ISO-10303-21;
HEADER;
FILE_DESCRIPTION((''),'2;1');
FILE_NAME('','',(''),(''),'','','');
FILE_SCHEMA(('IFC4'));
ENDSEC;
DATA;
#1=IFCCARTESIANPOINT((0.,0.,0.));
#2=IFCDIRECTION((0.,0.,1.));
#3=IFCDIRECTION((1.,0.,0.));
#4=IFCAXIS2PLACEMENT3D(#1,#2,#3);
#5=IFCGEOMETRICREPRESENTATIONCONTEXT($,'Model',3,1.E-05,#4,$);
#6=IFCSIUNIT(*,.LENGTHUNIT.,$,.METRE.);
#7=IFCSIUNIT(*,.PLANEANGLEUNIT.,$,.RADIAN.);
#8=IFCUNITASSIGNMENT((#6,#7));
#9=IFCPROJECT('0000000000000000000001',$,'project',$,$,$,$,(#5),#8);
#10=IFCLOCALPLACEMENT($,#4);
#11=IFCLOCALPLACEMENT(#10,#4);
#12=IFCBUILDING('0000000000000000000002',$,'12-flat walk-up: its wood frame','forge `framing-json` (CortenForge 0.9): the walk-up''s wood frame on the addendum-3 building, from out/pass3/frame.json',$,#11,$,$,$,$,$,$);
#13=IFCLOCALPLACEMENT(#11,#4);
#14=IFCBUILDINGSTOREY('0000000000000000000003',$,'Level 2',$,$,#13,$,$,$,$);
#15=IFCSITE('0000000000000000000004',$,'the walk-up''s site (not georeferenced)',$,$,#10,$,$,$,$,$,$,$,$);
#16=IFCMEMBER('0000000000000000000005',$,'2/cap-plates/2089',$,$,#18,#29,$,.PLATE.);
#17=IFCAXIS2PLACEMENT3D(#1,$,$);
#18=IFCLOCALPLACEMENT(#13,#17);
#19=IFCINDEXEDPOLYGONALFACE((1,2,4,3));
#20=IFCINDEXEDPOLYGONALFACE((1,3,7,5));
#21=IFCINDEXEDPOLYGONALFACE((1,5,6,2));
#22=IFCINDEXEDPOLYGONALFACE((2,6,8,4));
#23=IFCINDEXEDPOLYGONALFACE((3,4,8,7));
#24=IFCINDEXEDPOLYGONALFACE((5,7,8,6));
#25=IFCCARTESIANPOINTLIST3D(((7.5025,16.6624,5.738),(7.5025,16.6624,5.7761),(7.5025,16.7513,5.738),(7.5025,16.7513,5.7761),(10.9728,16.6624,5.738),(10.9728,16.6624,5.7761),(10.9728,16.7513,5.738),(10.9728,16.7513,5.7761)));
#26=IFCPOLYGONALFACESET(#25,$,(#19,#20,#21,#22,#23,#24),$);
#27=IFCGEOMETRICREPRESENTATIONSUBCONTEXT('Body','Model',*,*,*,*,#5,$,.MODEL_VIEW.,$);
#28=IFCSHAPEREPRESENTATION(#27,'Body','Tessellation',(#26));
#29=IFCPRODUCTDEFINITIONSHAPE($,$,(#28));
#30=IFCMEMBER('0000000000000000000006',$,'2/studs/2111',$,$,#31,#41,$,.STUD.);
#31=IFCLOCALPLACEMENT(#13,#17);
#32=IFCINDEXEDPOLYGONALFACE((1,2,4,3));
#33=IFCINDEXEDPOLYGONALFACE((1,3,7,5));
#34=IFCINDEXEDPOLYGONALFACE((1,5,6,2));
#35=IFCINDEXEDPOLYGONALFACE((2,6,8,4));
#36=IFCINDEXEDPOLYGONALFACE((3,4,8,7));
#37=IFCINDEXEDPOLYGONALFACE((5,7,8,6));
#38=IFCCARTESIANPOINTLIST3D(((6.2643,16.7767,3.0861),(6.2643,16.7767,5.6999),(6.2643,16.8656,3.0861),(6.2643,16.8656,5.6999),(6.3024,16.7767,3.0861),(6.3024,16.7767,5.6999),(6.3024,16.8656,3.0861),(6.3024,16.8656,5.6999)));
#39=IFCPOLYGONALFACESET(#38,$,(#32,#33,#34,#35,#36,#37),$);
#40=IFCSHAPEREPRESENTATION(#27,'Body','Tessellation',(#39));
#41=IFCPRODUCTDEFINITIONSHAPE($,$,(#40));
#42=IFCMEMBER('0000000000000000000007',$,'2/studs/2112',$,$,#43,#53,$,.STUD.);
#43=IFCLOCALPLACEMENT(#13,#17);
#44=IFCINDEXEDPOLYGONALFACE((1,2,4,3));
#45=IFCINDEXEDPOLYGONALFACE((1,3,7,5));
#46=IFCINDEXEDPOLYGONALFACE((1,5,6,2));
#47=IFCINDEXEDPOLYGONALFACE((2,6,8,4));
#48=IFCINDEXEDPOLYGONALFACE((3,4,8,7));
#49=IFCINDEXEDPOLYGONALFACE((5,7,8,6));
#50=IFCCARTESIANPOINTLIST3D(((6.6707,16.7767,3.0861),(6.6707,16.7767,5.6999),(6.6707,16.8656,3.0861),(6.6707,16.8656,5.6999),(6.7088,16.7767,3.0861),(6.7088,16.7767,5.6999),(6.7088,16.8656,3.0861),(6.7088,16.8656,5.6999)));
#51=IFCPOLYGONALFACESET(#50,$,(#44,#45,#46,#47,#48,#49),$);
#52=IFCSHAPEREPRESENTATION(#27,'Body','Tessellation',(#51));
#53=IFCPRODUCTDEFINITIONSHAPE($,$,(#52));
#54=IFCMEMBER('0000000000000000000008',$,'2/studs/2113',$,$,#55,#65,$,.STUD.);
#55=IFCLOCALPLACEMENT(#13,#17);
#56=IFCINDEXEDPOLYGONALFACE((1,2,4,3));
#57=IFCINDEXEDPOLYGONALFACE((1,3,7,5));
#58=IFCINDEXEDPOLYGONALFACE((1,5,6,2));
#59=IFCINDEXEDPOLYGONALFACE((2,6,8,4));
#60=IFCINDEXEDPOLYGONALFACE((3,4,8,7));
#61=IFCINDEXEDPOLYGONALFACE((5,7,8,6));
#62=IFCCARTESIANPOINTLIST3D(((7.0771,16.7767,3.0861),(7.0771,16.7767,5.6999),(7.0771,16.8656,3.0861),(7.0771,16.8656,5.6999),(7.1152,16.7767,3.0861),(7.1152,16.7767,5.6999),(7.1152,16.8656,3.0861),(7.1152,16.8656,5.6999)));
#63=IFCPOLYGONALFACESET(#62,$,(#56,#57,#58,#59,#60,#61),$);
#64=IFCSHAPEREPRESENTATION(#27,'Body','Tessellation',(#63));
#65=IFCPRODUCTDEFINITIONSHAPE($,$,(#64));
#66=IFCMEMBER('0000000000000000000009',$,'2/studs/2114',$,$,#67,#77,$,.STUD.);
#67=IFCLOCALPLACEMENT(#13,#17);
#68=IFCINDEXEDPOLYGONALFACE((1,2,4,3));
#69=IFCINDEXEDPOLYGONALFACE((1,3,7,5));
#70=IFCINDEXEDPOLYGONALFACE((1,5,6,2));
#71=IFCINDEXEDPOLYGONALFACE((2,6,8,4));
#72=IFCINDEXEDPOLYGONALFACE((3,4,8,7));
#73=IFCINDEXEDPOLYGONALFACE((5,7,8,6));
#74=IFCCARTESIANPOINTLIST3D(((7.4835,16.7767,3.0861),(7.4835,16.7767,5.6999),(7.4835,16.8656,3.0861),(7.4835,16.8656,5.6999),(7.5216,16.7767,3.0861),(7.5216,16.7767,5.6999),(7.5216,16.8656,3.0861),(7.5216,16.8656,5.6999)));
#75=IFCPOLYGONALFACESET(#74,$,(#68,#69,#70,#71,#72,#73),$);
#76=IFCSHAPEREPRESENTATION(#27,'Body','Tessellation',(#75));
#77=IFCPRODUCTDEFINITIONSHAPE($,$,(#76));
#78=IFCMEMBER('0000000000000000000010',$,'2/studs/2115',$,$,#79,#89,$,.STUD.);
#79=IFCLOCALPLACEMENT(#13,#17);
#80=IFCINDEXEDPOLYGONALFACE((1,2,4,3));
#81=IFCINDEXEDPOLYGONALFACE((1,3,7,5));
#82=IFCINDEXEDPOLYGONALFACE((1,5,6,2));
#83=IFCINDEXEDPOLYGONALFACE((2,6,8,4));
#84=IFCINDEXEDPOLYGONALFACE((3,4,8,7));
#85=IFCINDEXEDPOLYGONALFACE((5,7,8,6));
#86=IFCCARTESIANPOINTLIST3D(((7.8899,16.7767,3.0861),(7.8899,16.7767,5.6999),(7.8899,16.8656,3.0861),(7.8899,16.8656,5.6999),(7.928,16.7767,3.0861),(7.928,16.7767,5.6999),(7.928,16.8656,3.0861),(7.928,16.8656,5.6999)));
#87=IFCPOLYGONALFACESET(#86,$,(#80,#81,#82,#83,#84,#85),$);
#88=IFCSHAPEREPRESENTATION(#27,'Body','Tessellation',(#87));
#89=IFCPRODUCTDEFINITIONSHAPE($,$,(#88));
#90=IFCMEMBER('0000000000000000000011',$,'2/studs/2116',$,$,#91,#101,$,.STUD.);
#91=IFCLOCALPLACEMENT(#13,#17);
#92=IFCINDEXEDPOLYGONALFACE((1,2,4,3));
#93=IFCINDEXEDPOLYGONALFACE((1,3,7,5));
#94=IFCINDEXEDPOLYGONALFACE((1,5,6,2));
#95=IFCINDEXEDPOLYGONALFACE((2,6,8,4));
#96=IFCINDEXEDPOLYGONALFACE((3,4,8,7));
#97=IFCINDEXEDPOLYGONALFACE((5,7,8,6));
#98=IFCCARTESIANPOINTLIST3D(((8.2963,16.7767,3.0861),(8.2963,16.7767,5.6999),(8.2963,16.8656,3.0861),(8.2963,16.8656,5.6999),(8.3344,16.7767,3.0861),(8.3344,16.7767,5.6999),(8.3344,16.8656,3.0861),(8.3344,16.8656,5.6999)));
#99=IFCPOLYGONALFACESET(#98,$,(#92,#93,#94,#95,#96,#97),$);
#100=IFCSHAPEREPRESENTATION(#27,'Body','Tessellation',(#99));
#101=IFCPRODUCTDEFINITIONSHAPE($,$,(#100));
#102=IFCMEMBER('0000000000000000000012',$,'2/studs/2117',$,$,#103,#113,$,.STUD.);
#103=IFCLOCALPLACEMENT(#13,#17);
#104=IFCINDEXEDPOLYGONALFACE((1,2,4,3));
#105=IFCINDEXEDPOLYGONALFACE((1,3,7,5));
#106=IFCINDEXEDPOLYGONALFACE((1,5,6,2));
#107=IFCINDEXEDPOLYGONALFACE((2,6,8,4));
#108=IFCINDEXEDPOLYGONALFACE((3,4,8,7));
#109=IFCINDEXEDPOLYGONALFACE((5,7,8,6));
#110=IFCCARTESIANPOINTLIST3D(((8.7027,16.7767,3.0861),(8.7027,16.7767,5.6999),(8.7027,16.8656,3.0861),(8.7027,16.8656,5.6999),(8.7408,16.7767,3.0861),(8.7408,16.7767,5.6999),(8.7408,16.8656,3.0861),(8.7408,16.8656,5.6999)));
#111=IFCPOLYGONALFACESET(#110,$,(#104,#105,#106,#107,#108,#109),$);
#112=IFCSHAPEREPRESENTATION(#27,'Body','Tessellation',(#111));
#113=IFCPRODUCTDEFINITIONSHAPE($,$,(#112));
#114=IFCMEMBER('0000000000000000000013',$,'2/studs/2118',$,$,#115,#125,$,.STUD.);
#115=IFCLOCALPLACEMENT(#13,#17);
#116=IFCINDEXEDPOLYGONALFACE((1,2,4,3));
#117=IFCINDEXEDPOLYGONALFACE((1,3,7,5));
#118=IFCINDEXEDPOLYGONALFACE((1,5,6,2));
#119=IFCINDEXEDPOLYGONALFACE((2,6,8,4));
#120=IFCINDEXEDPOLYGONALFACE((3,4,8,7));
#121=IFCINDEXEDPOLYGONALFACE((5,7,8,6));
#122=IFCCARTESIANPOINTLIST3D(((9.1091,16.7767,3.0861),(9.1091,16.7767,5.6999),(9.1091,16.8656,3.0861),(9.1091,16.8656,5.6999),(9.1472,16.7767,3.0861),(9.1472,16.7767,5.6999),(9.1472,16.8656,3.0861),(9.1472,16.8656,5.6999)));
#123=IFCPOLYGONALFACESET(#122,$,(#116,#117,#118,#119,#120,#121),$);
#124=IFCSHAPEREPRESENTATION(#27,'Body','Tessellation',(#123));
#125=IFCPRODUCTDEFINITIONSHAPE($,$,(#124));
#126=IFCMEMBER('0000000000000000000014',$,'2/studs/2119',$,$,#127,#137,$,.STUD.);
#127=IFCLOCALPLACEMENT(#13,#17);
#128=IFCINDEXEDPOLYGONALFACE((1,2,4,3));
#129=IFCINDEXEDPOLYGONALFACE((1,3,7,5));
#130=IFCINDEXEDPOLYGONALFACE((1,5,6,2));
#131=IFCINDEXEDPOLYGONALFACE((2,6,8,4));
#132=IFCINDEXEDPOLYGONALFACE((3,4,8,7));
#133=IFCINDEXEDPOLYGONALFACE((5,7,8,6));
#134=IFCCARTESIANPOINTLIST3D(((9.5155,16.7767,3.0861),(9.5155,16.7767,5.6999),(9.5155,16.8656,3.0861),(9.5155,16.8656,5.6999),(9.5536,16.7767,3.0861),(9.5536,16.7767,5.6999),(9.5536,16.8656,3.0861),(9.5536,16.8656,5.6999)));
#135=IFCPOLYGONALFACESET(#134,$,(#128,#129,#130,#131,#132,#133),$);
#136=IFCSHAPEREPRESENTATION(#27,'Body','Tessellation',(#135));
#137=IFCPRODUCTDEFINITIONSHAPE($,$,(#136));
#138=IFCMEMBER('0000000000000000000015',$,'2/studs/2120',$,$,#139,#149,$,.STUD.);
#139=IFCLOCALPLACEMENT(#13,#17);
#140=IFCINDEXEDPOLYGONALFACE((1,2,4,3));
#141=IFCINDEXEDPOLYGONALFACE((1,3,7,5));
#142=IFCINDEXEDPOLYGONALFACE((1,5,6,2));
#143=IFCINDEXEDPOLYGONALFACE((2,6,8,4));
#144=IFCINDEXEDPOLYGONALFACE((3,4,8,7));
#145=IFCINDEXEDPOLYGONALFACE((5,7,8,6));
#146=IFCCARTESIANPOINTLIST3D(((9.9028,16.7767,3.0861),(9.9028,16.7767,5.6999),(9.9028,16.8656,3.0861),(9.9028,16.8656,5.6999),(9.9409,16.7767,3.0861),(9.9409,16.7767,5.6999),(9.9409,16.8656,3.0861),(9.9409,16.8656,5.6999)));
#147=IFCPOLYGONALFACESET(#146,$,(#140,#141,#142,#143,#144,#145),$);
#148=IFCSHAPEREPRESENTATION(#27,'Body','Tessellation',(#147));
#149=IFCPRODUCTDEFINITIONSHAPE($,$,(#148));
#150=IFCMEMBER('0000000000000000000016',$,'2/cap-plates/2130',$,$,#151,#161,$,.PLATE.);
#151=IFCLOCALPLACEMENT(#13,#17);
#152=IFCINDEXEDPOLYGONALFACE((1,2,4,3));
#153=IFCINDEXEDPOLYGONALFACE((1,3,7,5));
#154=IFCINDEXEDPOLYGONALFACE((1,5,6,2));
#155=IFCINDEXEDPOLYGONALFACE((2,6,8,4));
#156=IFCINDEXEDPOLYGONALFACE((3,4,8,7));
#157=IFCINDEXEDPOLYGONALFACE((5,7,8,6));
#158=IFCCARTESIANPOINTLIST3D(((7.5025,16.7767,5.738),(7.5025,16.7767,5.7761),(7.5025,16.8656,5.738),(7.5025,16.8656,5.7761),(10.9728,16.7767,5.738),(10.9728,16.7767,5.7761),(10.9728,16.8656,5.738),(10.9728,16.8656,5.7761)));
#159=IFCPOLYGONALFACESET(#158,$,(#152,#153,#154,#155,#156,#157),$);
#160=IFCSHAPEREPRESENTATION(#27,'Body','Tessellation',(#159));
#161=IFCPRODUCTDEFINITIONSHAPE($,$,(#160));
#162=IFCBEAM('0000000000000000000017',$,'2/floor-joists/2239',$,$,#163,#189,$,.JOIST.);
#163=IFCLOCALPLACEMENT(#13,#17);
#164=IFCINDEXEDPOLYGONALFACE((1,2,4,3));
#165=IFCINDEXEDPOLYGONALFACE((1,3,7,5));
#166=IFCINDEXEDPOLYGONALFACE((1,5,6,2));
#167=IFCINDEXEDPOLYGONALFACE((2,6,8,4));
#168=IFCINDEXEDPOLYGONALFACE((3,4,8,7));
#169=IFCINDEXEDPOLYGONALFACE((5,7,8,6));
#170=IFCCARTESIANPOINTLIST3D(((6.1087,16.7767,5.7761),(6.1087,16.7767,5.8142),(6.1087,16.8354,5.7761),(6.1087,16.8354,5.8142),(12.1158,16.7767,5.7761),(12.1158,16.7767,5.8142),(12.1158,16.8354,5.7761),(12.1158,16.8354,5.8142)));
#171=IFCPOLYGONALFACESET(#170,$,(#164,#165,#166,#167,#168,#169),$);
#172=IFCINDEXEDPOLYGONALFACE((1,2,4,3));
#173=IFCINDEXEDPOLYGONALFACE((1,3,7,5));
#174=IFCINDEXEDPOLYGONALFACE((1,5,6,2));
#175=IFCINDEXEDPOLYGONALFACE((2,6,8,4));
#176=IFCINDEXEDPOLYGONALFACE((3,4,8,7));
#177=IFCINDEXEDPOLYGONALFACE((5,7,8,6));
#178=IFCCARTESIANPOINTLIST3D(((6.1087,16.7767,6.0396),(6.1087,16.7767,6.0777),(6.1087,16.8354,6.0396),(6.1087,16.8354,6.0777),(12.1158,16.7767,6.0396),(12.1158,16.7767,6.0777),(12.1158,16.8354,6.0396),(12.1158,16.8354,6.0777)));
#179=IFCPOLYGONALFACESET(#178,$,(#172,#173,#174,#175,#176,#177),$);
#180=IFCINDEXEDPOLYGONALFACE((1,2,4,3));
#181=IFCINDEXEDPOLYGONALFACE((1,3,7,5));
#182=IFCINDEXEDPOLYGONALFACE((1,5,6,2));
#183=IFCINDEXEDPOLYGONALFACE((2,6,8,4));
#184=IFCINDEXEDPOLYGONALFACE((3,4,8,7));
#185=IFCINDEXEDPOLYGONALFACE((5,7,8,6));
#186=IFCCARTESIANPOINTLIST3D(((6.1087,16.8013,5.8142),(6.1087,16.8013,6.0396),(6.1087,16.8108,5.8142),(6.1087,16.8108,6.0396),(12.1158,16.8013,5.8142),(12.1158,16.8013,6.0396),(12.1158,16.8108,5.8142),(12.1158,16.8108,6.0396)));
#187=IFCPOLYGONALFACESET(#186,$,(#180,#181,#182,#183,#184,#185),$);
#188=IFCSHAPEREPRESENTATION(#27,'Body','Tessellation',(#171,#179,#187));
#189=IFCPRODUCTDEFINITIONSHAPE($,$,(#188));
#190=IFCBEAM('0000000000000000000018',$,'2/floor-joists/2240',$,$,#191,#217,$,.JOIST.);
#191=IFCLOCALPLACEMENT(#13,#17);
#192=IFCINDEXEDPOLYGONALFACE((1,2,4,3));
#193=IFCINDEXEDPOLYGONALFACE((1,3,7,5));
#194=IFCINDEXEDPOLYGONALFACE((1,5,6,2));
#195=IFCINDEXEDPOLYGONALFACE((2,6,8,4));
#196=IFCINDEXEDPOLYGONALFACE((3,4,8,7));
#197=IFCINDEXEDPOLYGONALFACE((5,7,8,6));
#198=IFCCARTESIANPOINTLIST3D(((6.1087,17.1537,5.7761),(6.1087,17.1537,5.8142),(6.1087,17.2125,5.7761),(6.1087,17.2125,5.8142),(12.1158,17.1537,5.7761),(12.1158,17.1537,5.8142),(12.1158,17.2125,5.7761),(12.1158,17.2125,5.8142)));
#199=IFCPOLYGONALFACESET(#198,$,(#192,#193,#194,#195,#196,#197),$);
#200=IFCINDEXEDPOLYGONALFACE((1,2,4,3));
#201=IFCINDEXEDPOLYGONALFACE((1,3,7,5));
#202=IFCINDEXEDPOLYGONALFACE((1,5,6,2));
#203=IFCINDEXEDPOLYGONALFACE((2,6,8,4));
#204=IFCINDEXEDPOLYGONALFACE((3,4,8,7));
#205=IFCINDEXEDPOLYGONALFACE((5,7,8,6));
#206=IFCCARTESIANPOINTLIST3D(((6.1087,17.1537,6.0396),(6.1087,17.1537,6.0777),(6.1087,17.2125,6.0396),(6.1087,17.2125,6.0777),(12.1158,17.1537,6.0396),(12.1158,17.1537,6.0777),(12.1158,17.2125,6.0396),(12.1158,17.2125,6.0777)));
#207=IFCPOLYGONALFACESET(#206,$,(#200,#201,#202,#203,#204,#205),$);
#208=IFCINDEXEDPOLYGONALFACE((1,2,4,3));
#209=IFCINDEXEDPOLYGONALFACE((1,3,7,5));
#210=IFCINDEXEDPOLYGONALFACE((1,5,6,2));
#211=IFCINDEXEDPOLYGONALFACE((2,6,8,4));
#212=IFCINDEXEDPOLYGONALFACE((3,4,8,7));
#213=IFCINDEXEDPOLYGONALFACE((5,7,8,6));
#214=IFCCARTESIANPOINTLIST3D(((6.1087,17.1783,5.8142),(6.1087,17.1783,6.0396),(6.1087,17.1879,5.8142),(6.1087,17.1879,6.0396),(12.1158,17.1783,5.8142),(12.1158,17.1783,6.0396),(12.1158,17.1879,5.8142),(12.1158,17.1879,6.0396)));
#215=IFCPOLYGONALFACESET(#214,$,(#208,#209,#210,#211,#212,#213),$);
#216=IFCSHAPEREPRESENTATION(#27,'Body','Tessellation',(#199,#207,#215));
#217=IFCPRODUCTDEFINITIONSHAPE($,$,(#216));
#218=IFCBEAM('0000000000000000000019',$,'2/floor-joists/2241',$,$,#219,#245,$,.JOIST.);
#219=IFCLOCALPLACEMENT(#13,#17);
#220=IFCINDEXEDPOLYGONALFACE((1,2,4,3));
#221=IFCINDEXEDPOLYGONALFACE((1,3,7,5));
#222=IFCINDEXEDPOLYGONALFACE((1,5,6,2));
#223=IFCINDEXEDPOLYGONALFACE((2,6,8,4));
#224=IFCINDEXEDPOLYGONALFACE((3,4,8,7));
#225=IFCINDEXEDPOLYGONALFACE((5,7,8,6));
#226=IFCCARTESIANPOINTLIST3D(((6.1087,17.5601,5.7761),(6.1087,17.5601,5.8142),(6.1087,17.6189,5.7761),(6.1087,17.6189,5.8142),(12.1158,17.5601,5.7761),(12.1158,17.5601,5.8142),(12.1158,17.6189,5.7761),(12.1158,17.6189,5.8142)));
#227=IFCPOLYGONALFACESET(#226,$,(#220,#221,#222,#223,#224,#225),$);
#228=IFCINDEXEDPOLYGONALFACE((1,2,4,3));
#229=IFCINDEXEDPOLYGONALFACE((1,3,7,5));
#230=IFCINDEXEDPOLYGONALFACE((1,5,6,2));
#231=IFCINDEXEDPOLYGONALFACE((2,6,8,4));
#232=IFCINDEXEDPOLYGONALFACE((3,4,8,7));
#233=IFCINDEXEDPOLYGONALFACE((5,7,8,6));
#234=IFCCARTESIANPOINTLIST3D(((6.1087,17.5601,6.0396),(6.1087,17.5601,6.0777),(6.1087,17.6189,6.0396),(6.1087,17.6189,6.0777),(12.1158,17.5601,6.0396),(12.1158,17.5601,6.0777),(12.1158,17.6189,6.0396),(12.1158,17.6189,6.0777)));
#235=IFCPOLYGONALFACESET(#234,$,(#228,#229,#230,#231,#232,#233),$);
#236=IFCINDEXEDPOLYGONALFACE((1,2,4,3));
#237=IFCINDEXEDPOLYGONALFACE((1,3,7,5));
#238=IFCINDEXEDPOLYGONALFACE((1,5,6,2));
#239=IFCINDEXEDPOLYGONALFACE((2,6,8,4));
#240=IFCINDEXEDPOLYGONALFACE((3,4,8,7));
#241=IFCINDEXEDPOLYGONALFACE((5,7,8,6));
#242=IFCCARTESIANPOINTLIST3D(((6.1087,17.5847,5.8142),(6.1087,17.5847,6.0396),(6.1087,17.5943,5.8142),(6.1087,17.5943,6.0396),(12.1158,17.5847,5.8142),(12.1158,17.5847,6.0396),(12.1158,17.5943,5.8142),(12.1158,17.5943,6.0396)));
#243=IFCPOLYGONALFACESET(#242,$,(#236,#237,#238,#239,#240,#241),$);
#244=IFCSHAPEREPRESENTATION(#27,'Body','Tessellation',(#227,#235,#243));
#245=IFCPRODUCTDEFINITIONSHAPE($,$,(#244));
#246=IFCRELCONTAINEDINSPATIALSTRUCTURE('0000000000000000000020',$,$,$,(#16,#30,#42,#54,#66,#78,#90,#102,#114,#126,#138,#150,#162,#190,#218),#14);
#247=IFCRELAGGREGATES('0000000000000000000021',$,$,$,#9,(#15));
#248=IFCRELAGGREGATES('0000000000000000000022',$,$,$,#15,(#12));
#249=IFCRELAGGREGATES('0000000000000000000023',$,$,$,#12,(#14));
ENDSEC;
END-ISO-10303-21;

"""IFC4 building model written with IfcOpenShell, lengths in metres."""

from ifc_helpers import new_model, si_unit, frame, frame_2d, origin, origin_with_axes, place, context, subcontext, project, spatial, rectangle, extrude, element, save


model = new_model("IFC4")

# Units and contexts
model_context = context("Model", 3, precision=1e-05, world=origin_with_axes())
body_context = subcontext(model_context, "Body", "Model", "MODEL_VIEW")
ifc_project = project(units=[si_unit("LENGTHUNIT", "METRE"), si_unit("PLANEANGLEUNIT", "RADIAN")], contexts=[model_context])

# Site, building, storey
site_placement = place(None, origin_with_axes())
site = spatial("IfcSite", under=ifc_project, at=site_placement, Name="the walk-up's site (not georeferenced)")
building_placement = place(site_placement, origin_with_axes())
building = spatial("IfcBuilding", under=site, at=building_placement, Name="12-flat walk-up: its wood frame", Description="forge `framing-json` (CortenForge 0.9): the walk-up's wood frame on the addendum-3 building, from out/pass3/frame.json")
storey_placement = place(building_placement, origin_with_axes())
storey = spatial("IfcBuildingStorey", under=building, at=storey_placement, Name="Level 2")

# Members
member_1_placement = place(storey_placement, frame((7.5025, 16.6624, 5.738), z_axis=(0.0, 0.0, 1.0), x_axis=(1.0, 0.0, 0.0)))
element("IfcMember", 1, at=member_1_placement, inside=storey, Name="2/cap-plates/2089", PredefinedType="PLATE", context=body_context, shape_type="SweptSolid", body=[
    extrude(rectangle(XDim=3.4703, YDim=0.0889, at=frame_2d((1.7351, 0.0444))), origin(), (0.0, 0.0, 1.0), 0.0381),
])
for number, where, z_axis, x_axis, name in (
    (2, (6.2643, 16.7767, 3.0861), (0.0, 0.0, 1.0), (1.0, 0.0, 0.0), "2/studs/2111"),
    (3, (6.6707, 16.7767, 3.0861), (0.0, 0.0, 1.0), (1.0, 0.0, 0.0), "2/studs/2112"),
    (4, (7.0771, 16.7767, 3.0861), (0.0, 0.0, 1.0), (1.0, 0.0, 0.0), "2/studs/2113"),
    (5, (7.4835, 16.7767, 3.0861), (0.0, 0.0, 1.0), (1.0, 0.0, 0.0), "2/studs/2114"),
    (6, (7.8899, 16.7767, 3.0861), (0.0, 0.0, 1.0), (1.0, 0.0, 0.0), "2/studs/2115"),
    (7, (8.2963, 16.7767, 3.0861), (0.0, 0.0, 1.0), (1.0, 0.0, 0.0), "2/studs/2116"),
    (8, (8.7027, 16.7767, 3.0861), (0.0, 0.0, 1.0), (1.0, 0.0, 0.0), "2/studs/2117"),
    (9, (9.1091, 16.7767, 3.0861), (0.0, 0.0, 1.0), (1.0, 0.0, 0.0), "2/studs/2118"),
    (10, (9.5155, 16.7767, 3.0861), (0.0, 0.0, 1.0), (1.0, 0.0, 0.0), "2/studs/2119"),
    (11, (9.9028, 16.7767, 3.0861), (0.0, 0.0, 1.0), (1.0, 0.0, 0.0), "2/studs/2120"),
):
    element("IfcMember", number, at=place(storey_placement, frame(where, z_axis=z_axis, x_axis=x_axis)), inside=storey, Name=name, PredefinedType="STUD", context=body_context, shape_type="SweptSolid", body=[
        extrude(rectangle(XDim=0.0381, YDim=0.0889, at=frame_2d((0.0191, 0.0444))), origin(), (0.0, 0.0, 1.0), 2.6138),
    ])
member_2_placement = place(storey_placement, frame((7.5025, 16.7767, 5.738), z_axis=(0.0, 0.0, 1.0), x_axis=(1.0, 0.0, 0.0)))
element("IfcMember", 12, at=member_2_placement, inside=storey, Name="2/cap-plates/2130", PredefinedType="PLATE", context=body_context, shape_type="SweptSolid", body=[
    extrude(rectangle(XDim=3.4703, YDim=0.0889, at=frame_2d((1.7351, 0.0444))), origin(), (0.0, 0.0, 1.0), 0.0381),
])

# Beams
beam_1_placement = place(storey_placement, frame((6.1087, 16.7767, 5.7761), z_axis=(0.0, 0.0, 1.0), x_axis=(1.0, 0.0, 0.0)))
element("IfcBeam", 13, at=beam_1_placement, inside=storey, Name="2/floor-joists/2239", PredefinedType="JOIST", context=body_context, shape_type="SweptSolid", body=[
    extrude(rectangle(XDim=6.0071, YDim=0.0587, at=frame_2d((3.0036, 0.0294))), origin(), (0.0, 0.0, 1.0), 0.0381),
    extrude(rectangle(XDim=6.0071, YDim=0.0587, at=frame_2d((3.0036, 0.0294))), frame((0.0, 0.0, 0.2635)), (0.0, 0.0, 1.0), 0.0381),
    extrude(rectangle(XDim=6.0071, YDim=0.0095, at=frame_2d((3.0036, 0.0048))), frame((0.0, 0.0246, 0.0381)), (0.0, 0.0, 1.0), 0.2254),
])
beam_2_placement = place(storey_placement, frame((6.1087, 17.1537, 5.7761), z_axis=(0.0, 0.0, 1.0), x_axis=(1.0, 0.0, 0.0)))
element("IfcBeam", 14, at=beam_2_placement, inside=storey, Name="2/floor-joists/2240", PredefinedType="JOIST", context=body_context, shape_type="SweptSolid", body=[
    extrude(rectangle(XDim=6.0071, YDim=0.0587, at=frame_2d((3.0036, 0.0294))), origin(), (0.0, 0.0, 1.0), 0.0381),
    extrude(rectangle(XDim=6.0071, YDim=0.0587, at=frame_2d((3.0036, 0.0294))), frame((0.0, 0.0, 0.2635)), (0.0, 0.0, 1.0), 0.0381),
    extrude(rectangle(XDim=6.0071, YDim=0.0095, at=frame_2d((3.0036, 0.0048))), frame((0.0, 0.0246, 0.0381)), (0.0, 0.0, 1.0), 0.2254),
])
beam_3_placement = place(storey_placement, frame((6.1087, 17.5601, 5.7761), z_axis=(0.0, 0.0, 1.0), x_axis=(1.0, 0.0, 0.0)))
element("IfcBeam", 15, at=beam_3_placement, inside=storey, Name="2/floor-joists/2241", PredefinedType="JOIST", context=body_context, shape_type="SweptSolid", body=[
    extrude(rectangle(XDim=6.0071, YDim=0.0587, at=frame_2d((3.0036, 0.0294))), origin(), (0.0, 0.0, 1.0), 0.0381),
    extrude(rectangle(XDim=6.0071, YDim=0.0587, at=frame_2d((3.0036, 0.0294))), frame((0.0, 0.0, 0.2635)), (0.0, 0.0, 1.0), 0.0381),
    extrude(rectangle(XDim=6.0071, YDim=0.0095, at=frame_2d((3.0036, 0.0048))), frame((0.0, 0.0246, 0.0381)), (0.0, 0.0, 1.0), 0.2254),
])

save(model, "model.ifc")
